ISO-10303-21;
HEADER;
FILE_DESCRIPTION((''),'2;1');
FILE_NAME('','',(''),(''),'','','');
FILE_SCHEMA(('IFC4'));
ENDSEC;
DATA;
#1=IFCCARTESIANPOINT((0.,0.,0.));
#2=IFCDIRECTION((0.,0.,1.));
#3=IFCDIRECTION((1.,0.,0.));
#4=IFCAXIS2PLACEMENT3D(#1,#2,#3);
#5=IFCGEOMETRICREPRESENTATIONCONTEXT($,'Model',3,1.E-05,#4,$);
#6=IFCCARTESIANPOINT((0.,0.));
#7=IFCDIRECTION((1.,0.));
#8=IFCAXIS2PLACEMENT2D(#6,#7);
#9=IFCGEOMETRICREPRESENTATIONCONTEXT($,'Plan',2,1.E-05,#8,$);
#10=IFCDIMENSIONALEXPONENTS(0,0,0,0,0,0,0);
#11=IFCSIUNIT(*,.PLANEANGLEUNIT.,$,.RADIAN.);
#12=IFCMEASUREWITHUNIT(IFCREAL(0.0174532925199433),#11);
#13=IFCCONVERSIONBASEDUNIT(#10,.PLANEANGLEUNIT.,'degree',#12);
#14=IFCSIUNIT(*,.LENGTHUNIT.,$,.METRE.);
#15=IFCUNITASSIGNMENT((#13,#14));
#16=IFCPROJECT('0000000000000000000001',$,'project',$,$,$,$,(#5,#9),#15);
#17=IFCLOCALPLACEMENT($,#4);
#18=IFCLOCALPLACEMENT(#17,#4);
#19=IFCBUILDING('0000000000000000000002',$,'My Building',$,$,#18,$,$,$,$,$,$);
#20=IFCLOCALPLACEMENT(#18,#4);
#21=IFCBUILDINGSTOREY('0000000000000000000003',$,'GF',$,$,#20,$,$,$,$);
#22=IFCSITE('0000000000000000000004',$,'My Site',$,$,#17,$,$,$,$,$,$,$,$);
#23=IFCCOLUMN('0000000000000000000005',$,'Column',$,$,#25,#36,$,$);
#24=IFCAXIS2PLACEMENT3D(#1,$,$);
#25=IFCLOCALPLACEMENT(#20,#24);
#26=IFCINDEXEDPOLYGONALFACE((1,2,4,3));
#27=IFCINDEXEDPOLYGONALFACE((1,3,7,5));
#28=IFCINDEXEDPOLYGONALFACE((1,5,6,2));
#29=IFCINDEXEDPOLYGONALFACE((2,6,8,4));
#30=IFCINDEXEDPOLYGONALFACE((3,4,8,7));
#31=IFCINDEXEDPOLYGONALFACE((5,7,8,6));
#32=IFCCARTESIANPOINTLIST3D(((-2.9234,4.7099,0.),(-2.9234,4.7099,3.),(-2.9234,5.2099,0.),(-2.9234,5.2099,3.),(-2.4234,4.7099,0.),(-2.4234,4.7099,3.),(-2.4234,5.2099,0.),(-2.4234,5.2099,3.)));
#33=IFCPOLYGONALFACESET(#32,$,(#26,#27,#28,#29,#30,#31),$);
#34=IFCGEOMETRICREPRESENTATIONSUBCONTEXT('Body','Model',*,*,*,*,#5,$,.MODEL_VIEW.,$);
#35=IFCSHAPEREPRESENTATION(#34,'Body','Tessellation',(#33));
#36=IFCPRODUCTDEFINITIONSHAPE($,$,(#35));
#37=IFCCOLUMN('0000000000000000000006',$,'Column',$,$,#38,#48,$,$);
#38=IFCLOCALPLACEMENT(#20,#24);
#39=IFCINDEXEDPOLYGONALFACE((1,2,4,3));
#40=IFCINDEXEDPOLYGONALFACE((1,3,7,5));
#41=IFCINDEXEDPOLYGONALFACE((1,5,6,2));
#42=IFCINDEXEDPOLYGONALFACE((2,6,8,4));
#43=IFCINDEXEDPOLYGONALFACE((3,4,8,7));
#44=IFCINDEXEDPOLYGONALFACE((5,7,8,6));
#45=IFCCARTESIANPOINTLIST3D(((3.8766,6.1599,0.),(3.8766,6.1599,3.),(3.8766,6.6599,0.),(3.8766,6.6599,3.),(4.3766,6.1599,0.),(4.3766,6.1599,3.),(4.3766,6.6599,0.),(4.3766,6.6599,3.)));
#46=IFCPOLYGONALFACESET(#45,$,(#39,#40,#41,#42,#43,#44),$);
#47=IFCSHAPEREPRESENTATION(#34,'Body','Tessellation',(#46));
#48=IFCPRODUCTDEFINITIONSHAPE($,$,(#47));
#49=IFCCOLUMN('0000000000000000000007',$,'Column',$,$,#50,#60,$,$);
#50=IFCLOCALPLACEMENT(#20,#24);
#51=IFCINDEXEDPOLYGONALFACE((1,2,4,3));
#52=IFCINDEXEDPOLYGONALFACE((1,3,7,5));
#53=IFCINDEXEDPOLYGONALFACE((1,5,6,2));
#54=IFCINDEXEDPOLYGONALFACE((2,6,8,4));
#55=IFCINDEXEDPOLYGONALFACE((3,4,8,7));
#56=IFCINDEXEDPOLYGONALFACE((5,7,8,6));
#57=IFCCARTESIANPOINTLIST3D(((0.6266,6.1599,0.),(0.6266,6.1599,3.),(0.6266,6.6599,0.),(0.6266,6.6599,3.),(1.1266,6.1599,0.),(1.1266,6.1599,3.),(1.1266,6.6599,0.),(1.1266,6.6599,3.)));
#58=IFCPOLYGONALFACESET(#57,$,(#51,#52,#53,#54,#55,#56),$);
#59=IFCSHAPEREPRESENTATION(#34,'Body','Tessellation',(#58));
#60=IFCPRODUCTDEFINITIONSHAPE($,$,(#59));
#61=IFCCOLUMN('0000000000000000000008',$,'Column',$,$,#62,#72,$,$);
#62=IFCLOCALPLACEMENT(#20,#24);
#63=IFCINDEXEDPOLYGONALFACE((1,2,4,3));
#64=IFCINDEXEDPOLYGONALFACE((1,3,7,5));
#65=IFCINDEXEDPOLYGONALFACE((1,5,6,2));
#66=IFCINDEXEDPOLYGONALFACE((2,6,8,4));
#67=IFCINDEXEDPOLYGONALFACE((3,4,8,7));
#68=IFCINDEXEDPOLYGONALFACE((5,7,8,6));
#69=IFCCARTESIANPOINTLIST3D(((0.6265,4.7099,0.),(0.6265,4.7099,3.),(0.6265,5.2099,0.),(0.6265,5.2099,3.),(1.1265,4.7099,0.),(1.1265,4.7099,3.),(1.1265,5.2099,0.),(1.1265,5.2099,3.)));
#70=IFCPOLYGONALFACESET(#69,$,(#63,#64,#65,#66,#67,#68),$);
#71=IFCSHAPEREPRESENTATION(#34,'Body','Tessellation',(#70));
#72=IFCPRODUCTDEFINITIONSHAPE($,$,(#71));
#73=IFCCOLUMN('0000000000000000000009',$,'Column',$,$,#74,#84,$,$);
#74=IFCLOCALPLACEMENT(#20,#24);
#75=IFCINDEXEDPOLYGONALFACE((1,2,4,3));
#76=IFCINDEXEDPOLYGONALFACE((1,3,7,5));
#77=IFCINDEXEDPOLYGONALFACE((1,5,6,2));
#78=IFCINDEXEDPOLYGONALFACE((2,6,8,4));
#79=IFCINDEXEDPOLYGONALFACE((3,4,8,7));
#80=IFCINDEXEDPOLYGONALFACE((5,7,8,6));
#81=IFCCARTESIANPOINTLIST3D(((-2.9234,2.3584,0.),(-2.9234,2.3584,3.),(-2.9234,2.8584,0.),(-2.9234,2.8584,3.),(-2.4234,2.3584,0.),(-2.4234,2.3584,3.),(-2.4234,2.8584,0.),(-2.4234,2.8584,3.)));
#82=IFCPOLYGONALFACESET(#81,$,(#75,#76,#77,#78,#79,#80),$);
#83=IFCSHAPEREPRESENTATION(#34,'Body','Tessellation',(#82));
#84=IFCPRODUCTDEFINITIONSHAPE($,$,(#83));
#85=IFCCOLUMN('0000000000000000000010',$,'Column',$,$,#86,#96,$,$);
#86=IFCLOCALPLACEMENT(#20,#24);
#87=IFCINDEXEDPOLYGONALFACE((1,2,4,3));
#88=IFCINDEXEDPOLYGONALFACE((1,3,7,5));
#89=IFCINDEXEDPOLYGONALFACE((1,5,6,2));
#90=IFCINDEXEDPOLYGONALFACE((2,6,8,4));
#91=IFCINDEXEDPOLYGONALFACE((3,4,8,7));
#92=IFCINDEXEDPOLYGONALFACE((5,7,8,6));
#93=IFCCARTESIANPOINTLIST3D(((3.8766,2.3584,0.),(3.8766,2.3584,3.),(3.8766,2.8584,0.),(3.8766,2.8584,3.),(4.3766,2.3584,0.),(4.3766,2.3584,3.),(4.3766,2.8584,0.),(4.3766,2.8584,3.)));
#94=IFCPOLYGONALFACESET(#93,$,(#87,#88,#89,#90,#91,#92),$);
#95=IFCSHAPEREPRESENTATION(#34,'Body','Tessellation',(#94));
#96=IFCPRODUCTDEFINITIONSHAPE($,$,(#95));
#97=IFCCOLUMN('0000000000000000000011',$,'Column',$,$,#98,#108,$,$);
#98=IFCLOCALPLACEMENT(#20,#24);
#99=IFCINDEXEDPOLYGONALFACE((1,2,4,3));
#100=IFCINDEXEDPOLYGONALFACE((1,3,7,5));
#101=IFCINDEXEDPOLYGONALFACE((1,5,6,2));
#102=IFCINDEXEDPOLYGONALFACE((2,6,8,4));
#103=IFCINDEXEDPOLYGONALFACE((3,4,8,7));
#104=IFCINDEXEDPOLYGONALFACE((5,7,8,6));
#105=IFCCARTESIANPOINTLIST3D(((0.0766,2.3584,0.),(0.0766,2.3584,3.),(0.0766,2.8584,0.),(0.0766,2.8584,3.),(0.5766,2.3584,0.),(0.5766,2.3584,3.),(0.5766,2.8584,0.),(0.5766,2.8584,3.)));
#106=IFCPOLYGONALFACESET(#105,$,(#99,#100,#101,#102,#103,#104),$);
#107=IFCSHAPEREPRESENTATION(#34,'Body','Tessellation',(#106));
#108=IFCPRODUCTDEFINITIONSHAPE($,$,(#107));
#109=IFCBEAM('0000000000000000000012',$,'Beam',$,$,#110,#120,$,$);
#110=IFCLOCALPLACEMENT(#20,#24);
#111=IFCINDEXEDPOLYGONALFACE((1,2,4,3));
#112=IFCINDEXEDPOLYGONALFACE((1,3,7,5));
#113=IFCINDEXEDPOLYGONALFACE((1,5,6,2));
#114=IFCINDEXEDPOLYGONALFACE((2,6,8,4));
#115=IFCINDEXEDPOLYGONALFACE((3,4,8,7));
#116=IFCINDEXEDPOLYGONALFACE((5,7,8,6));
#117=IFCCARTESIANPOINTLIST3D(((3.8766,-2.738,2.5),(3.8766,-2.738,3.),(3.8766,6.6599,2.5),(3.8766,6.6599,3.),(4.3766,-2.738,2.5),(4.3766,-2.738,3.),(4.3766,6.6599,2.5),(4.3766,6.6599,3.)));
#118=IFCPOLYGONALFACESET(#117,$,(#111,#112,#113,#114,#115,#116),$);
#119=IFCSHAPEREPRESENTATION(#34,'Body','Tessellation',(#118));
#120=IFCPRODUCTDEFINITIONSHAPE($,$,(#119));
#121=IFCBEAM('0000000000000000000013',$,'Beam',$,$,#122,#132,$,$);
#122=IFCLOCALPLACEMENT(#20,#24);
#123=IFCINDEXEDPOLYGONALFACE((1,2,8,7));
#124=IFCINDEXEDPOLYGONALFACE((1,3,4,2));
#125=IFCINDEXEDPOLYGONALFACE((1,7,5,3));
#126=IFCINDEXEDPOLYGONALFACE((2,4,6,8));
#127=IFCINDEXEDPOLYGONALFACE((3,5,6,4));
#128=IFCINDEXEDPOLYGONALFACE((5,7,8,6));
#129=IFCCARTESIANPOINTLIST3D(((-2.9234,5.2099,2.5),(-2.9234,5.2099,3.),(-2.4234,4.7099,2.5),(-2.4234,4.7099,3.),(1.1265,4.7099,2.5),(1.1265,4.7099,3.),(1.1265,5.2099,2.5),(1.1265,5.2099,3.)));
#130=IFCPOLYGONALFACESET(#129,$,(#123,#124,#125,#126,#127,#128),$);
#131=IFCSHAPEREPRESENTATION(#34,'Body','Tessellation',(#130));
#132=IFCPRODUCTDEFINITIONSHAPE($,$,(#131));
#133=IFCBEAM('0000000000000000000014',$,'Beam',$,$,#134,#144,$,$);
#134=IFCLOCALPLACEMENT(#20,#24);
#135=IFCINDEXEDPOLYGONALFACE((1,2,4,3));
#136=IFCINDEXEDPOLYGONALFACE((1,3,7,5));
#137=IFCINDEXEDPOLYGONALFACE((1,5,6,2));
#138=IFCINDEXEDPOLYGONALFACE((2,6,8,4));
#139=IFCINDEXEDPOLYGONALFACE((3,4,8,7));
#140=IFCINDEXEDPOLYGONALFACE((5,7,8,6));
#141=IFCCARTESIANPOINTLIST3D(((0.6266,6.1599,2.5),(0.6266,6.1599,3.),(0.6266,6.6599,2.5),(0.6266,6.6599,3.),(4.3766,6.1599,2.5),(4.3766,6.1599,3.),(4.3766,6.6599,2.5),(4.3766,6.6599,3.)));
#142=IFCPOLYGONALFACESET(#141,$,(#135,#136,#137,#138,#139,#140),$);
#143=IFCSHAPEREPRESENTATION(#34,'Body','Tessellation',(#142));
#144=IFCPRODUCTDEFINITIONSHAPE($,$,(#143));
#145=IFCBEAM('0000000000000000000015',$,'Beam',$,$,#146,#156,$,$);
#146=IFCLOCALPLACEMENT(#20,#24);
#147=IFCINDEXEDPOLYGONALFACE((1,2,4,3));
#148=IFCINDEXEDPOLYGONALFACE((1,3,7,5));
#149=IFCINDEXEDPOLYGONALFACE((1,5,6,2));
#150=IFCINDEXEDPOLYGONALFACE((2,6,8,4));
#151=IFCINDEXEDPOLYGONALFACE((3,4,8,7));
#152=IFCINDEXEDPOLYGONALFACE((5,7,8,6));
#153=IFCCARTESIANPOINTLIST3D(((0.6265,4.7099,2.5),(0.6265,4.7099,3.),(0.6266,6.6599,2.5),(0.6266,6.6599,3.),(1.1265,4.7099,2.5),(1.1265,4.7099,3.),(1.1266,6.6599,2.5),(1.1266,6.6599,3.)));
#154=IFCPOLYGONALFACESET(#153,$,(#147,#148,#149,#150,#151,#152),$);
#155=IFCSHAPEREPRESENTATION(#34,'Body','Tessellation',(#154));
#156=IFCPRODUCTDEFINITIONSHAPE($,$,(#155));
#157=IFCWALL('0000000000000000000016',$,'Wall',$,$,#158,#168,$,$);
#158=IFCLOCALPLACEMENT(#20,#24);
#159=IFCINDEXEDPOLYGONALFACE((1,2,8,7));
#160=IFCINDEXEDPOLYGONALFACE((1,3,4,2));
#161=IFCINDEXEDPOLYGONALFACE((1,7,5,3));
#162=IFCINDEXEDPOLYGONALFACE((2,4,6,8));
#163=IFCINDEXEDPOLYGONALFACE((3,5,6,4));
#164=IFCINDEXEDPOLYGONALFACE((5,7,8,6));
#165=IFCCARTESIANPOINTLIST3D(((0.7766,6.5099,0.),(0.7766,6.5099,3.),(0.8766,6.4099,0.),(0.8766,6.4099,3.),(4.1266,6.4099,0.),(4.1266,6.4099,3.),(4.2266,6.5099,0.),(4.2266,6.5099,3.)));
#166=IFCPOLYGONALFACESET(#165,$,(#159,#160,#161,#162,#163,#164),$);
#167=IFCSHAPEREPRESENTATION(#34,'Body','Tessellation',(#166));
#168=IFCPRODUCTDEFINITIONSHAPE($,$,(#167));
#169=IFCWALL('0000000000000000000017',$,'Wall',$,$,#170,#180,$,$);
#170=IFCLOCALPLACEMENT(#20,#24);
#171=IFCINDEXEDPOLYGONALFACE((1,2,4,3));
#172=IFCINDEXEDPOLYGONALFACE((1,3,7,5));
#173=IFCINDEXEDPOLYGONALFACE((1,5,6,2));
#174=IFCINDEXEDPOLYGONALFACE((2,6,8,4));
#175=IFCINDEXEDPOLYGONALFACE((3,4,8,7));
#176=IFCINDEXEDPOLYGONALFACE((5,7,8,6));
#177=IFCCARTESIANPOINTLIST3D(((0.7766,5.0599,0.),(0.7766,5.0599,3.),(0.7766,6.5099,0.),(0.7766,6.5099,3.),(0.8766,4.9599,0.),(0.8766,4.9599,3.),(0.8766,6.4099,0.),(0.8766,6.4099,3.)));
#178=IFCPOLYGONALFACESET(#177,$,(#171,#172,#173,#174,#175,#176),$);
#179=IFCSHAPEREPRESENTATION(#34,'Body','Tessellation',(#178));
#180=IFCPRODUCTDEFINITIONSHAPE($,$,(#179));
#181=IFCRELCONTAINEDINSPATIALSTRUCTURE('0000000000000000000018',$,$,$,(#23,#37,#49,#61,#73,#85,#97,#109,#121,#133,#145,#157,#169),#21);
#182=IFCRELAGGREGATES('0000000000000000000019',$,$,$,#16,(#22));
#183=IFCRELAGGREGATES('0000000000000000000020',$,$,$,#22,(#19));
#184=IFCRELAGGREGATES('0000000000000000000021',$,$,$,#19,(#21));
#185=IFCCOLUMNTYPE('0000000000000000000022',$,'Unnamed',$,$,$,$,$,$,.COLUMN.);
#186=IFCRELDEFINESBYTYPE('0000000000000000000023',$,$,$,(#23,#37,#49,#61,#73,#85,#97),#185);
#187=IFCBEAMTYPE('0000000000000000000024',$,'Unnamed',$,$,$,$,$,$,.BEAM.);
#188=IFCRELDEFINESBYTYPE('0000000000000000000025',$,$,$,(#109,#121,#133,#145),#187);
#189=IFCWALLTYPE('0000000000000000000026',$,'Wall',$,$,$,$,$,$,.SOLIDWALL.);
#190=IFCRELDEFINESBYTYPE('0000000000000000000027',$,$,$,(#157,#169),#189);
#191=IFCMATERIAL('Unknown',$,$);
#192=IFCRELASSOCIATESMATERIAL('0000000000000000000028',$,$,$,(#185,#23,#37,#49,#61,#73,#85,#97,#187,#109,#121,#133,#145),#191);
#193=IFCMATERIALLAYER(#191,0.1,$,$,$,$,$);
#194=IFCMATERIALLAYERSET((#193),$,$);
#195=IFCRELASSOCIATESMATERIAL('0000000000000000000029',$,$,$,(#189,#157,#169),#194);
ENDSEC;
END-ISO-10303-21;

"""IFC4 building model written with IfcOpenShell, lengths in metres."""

from ifc_helpers import new_model, entity, si_unit, converted_unit, frame, origin_with_axes, origin_2d_with_axis, place, context, subcontext, project, spatial, line, indexed_curve, rectangle, outline, extrude, clip, halfspace, material, layer, layer_set, layer_usage, material_profile, profile_set, profile_usage, type_object, element, save


model = new_model("IFC4")

# Units and contexts
model_context = context("Model", 3, precision=1e-05, world=origin_with_axes())
plan_context = context("Plan", 2, precision=1e-05, world=origin_2d_with_axis())
body_context_1 = subcontext(model_context, "Body", "Model", "MODEL_VIEW")
ifc_project = project(units=[converted_unit("PLANEANGLEUNIT", "degree", entity("IfcReal", 0.0174532925199433), si_unit("PLANEANGLEUNIT", "RADIAN"), dimensions=[0, 0, 0, 0, 0, 0, 0]), si_unit("LENGTHUNIT", "METRE")], contexts=[model_context, plan_context])

# Site, building, storey
site_placement = place(None, origin_with_axes())
site = spatial("IfcSite", under=ifc_project, at=site_placement, Name="My Site")
building_placement = place(site_placement, origin_with_axes())
building = spatial("IfcBuilding", under=site, at=building_placement, Name="My Building")
storey_placement = place(building_placement, origin_with_axes())
storey = spatial("IfcBuildingStorey", under=building, at=storey_placement, Name="GF")

# Columns
ifc_material = material(Name="Unknown")
ifc_material_profile_1 = material_profile(ifc_material, rectangle(XDim=0.5, YDim=0.5))
ifc_profile_set_1 = profile_set([ifc_material_profile_1])
ifc_profile_usage_1 = profile_usage(ifc_profile_set_1, cardinal=5)
column_type = type_object("IfcColumnType", Name="Unnamed", PredefinedType="COLUMN", material=ifc_profile_set_1)
column_1_placement = place(storey_placement, frame((-2.6734, 4.9599, 0.0), z_axis=(0.0, 0.0, 1.0), x_axis=(1.0, 0.0, 0.0)))
element("IfcColumn", 1, at=column_1_placement, inside=storey, type_object=column_type, material=ifc_profile_usage_1, Name="Column", context=body_context_1, shape_type="SweptSolid", body=[
    extrude(rectangle(XDim=0.5, YDim=0.5), origin_with_axes(), (0.0, 0.0, 1.0), 3.0),
])
ifc_profile_usage_2 = profile_usage(ifc_profile_set_1, cardinal=5)
column_2_placement = place(storey_placement, frame((4.1266, 6.4099, 0.0), z_axis=(0.0, 0.0, 1.0), x_axis=(1.0, 0.0, 0.0)))
element("IfcColumn", 2, at=column_2_placement, inside=storey, type_object=column_type, material=ifc_profile_usage_2, Name="Column", context=body_context_1, shape_type="SweptSolid", body=[
    extrude(rectangle(XDim=0.5, YDim=0.5), origin_with_axes(), (0.0, 0.0, 1.0), 3.0),
])
ifc_profile_usage_3 = profile_usage(ifc_profile_set_1, cardinal=5)
column_3_placement = place(storey_placement, frame((0.8766, 6.4099, 0.0), z_axis=(0.0, 0.0, 1.0), x_axis=(1.0, 0.0, 0.0)))
element("IfcColumn", 3, at=column_3_placement, inside=storey, type_object=column_type, material=ifc_profile_usage_3, Name="Column", context=body_context_1, shape_type="SweptSolid", body=[
    extrude(rectangle(XDim=0.5, YDim=0.5), origin_with_axes(), (0.0, 0.0, 1.0), 3.0),
])
ifc_profile_usage_4 = profile_usage(ifc_profile_set_1, cardinal=5)
column_4_placement = place(storey_placement, frame((0.8765, 4.9599, 0.0), z_axis=(0.0, 0.0, 1.0), x_axis=(1.0, 0.0, 0.0)))
element("IfcColumn", 4, at=column_4_placement, inside=storey, type_object=column_type, material=ifc_profile_usage_4, Name="Column", context=body_context_1, shape_type="SweptSolid", body=[
    extrude(rectangle(XDim=0.5, YDim=0.5), origin_with_axes(), (0.0, 0.0, 1.0), 3.0),
])
ifc_profile_usage_5 = profile_usage(ifc_profile_set_1, cardinal=5)
column_5_placement = place(storey_placement, frame((-2.6734, 2.6084, 0.0), z_axis=(0.0, 0.0, 1.0), x_axis=(1.0, 0.0, 0.0)))
element("IfcColumn", 5, at=column_5_placement, inside=storey, type_object=column_type, material=ifc_profile_usage_5, Name="Column", context=body_context_1, shape_type="SweptSolid", body=[
    extrude(rectangle(XDim=0.5, YDim=0.5), origin_with_axes(), (0.0, 0.0, 1.0), 3.0),
])
ifc_profile_usage_6 = profile_usage(ifc_profile_set_1, cardinal=5)
column_6_placement = place(storey_placement, frame((4.1266, 2.6084, 0.0), z_axis=(0.0, 0.0, 1.0), x_axis=(1.0, 0.0, 0.0)))
element("IfcColumn", 6, at=column_6_placement, inside=storey, type_object=column_type, material=ifc_profile_usage_6, Name="Column", context=body_context_1, shape_type="SweptSolid", body=[
    extrude(rectangle(XDim=0.5, YDim=0.5), origin_with_axes(), (0.0, 0.0, 1.0), 3.0),
])
ifc_profile_usage_7 = profile_usage(ifc_profile_set_1, cardinal=5)
column_7_placement = place(storey_placement, frame((0.3266, 2.6084, 0.0), z_axis=(0.0, 0.0, 1.0), x_axis=(1.0, 0.0, 0.0)))
element("IfcColumn", 7, at=column_7_placement, inside=storey, type_object=column_type, material=ifc_profile_usage_7, Name="Column", context=body_context_1, shape_type="SweptSolid", body=[
    extrude(rectangle(XDim=0.5, YDim=0.5), origin_with_axes(), (0.0, 0.0, 1.0), 3.0),
])

# Beams
ifc_material_profile_2 = material_profile(ifc_material, rectangle(XDim=0.5, YDim=0.5))
ifc_profile_set_2 = profile_set([ifc_material_profile_2])
ifc_profile_usage_8 = profile_usage(ifc_profile_set_2, cardinal=7)
beam_type = type_object("IfcBeamType", Name="Unnamed", PredefinedType="BEAM", material=ifc_profile_set_2)
beam_1_placement = place(storey_placement, frame((4.3766, 6.6599, 3.0), z_axis=(0.0, -1.0, 0.0), x_axis=(1.0, 0.0, 0.0)))
element("IfcBeam", 8, at=beam_1_placement, inside=storey, type_object=beam_type, material=ifc_profile_usage_8, Name="Beam", context=body_context_1, shape_type="SweptSolid", body=[
    extrude(rectangle(XDim=0.5, YDim=0.5), frame((-0.25, -0.25, 0.0), z_axis=(0.0, 0.0, 1.0), x_axis=(1.0, 0.0, 0.0)), (0.0, 0.0, 1.0), 9.3979),
])
ifc_profile_usage_9 = profile_usage(ifc_profile_set_2, cardinal=7)
beam_2_placement = place(storey_placement, frame((-2.9234, 5.2099, 3.0), z_axis=(1.0, -0.000002, 0.0), x_axis=(0.000002, 1.0, 0.0)))
element("IfcBeam", 9, at=beam_2_placement, inside=storey, type_object=beam_type, material=ifc_profile_usage_9, Name="Beam", context=body_context_1, shape_type="Clipping", body=[
    clip(extrude(rectangle(XDim=0.5, YDim=0.5), frame((-0.25, -0.25, 0.0), z_axis=(0.0, 0.0, 1.0), x_axis=(1.0, 0.0, 0.0)), (0.0, 0.0, 1.0), 4.0499), halfspace(frame((0.0, -3.0, 0.0), z_axis=(-0.707107, 0.0, -0.707106), x_axis=(0.0, 1.0, 0.0)), False)),
])
ifc_profile_usage_10 = profile_usage(ifc_profile_set_2, cardinal=7)
beam_3_placement = place(storey_placement, frame((0.6266, 6.6599, 3.0), z_axis=(1.0, 0.0, 0.0), x_axis=(0.0, 1.0, 0.0)))
element("IfcBeam", 10, at=beam_3_placement, inside=storey, type_object=beam_type, material=ifc_profile_usage_10, Name="Beam", context=body_context_1, shape_type="SweptSolid", body=[
    extrude(rectangle(XDim=0.5, YDim=0.5), frame((-0.25, -0.25, 0.0), z_axis=(0.0, 0.0, 1.0), x_axis=(1.0, 0.0, 0.0)), (0.0, 0.0, 1.0), 3.75),
])
ifc_profile_usage_11 = profile_usage(ifc_profile_set_2, cardinal=7)
beam_4_placement = place(storey_placement, frame((1.1266, 6.6599, 3.0), z_axis=(-0.000051, -1.0, 0.0), x_axis=(1.0, -0.000051, 0.0)))
element("IfcBeam", 11, at=beam_4_placement, inside=storey, type_object=beam_type, material=ifc_profile_usage_11, Name="Beam", context=body_context_1, shape_type="SweptSolid", body=[
    extrude(rectangle(XDim=0.5, YDim=0.5), frame((-0.25, -0.25, 0.0), z_axis=(0.0, 0.0, 1.0), x_axis=(1.0, 0.0, 0.0)), (0.0, 0.0, 1.0), 1.95),
])

# Walls
ifc_layer = layer(ifc_material, 0.1)
ifc_layer_set = layer_set([ifc_layer])
ifc_layer_usage_1 = layer_usage(ifc_layer_set, "AXIS2", "POSITIVE", 0.0)
wall_type = type_object("IfcWallType", Name="Wall", PredefinedType="SOLIDWALL", material=ifc_layer_set)
wall_1_placement = place(storey_placement, frame((4.2266, 6.5099, 0.0), z_axis=(0.0, 0.0, 1.0), x_axis=(-1.0, 0.0, 0.0)))
element("IfcWall", 12, at=wall_1_placement, inside=storey, type_object=wall_type, material=ifc_layer_usage_1, Name="Wall", context=body_context_1, shape_type="SweptSolid", body=[
    extrude(outline(indexed_curve([(0.0, 0.0), (0.1, 0.1), (3.35, 0.1), (3.45, 0.0)], segments=[line(1, 2, 3, 4, 1)])), origin_with_axes(), (0.0, 0.0, 1.0), 3.0),
])
ifc_layer_usage_2 = layer_usage(ifc_layer_set, "AXIS2", "POSITIVE", 0.0)
wall_2_placement = place(storey_placement, frame((0.7766, 6.5099, 0.0), z_axis=(0.0, 0.0, 1.0), x_axis=(0.0, -1.0, 0.0)))
element("IfcWall", 13, at=wall_2_placement, inside=storey, type_object=wall_type, material=ifc_layer_usage_2, Name="Wall", context=body_context_1, shape_type="SweptSolid", body=[
    extrude(outline(indexed_curve([(0.0, 0.0), (0.1, 0.1), (1.55, 0.1), (1.45, 0.0)], segments=[line(1, 2, 3, 4, 1)])), origin_with_axes(), (0.0, 0.0, 1.0), 3.0),
])

save(model, "model.ifc")
